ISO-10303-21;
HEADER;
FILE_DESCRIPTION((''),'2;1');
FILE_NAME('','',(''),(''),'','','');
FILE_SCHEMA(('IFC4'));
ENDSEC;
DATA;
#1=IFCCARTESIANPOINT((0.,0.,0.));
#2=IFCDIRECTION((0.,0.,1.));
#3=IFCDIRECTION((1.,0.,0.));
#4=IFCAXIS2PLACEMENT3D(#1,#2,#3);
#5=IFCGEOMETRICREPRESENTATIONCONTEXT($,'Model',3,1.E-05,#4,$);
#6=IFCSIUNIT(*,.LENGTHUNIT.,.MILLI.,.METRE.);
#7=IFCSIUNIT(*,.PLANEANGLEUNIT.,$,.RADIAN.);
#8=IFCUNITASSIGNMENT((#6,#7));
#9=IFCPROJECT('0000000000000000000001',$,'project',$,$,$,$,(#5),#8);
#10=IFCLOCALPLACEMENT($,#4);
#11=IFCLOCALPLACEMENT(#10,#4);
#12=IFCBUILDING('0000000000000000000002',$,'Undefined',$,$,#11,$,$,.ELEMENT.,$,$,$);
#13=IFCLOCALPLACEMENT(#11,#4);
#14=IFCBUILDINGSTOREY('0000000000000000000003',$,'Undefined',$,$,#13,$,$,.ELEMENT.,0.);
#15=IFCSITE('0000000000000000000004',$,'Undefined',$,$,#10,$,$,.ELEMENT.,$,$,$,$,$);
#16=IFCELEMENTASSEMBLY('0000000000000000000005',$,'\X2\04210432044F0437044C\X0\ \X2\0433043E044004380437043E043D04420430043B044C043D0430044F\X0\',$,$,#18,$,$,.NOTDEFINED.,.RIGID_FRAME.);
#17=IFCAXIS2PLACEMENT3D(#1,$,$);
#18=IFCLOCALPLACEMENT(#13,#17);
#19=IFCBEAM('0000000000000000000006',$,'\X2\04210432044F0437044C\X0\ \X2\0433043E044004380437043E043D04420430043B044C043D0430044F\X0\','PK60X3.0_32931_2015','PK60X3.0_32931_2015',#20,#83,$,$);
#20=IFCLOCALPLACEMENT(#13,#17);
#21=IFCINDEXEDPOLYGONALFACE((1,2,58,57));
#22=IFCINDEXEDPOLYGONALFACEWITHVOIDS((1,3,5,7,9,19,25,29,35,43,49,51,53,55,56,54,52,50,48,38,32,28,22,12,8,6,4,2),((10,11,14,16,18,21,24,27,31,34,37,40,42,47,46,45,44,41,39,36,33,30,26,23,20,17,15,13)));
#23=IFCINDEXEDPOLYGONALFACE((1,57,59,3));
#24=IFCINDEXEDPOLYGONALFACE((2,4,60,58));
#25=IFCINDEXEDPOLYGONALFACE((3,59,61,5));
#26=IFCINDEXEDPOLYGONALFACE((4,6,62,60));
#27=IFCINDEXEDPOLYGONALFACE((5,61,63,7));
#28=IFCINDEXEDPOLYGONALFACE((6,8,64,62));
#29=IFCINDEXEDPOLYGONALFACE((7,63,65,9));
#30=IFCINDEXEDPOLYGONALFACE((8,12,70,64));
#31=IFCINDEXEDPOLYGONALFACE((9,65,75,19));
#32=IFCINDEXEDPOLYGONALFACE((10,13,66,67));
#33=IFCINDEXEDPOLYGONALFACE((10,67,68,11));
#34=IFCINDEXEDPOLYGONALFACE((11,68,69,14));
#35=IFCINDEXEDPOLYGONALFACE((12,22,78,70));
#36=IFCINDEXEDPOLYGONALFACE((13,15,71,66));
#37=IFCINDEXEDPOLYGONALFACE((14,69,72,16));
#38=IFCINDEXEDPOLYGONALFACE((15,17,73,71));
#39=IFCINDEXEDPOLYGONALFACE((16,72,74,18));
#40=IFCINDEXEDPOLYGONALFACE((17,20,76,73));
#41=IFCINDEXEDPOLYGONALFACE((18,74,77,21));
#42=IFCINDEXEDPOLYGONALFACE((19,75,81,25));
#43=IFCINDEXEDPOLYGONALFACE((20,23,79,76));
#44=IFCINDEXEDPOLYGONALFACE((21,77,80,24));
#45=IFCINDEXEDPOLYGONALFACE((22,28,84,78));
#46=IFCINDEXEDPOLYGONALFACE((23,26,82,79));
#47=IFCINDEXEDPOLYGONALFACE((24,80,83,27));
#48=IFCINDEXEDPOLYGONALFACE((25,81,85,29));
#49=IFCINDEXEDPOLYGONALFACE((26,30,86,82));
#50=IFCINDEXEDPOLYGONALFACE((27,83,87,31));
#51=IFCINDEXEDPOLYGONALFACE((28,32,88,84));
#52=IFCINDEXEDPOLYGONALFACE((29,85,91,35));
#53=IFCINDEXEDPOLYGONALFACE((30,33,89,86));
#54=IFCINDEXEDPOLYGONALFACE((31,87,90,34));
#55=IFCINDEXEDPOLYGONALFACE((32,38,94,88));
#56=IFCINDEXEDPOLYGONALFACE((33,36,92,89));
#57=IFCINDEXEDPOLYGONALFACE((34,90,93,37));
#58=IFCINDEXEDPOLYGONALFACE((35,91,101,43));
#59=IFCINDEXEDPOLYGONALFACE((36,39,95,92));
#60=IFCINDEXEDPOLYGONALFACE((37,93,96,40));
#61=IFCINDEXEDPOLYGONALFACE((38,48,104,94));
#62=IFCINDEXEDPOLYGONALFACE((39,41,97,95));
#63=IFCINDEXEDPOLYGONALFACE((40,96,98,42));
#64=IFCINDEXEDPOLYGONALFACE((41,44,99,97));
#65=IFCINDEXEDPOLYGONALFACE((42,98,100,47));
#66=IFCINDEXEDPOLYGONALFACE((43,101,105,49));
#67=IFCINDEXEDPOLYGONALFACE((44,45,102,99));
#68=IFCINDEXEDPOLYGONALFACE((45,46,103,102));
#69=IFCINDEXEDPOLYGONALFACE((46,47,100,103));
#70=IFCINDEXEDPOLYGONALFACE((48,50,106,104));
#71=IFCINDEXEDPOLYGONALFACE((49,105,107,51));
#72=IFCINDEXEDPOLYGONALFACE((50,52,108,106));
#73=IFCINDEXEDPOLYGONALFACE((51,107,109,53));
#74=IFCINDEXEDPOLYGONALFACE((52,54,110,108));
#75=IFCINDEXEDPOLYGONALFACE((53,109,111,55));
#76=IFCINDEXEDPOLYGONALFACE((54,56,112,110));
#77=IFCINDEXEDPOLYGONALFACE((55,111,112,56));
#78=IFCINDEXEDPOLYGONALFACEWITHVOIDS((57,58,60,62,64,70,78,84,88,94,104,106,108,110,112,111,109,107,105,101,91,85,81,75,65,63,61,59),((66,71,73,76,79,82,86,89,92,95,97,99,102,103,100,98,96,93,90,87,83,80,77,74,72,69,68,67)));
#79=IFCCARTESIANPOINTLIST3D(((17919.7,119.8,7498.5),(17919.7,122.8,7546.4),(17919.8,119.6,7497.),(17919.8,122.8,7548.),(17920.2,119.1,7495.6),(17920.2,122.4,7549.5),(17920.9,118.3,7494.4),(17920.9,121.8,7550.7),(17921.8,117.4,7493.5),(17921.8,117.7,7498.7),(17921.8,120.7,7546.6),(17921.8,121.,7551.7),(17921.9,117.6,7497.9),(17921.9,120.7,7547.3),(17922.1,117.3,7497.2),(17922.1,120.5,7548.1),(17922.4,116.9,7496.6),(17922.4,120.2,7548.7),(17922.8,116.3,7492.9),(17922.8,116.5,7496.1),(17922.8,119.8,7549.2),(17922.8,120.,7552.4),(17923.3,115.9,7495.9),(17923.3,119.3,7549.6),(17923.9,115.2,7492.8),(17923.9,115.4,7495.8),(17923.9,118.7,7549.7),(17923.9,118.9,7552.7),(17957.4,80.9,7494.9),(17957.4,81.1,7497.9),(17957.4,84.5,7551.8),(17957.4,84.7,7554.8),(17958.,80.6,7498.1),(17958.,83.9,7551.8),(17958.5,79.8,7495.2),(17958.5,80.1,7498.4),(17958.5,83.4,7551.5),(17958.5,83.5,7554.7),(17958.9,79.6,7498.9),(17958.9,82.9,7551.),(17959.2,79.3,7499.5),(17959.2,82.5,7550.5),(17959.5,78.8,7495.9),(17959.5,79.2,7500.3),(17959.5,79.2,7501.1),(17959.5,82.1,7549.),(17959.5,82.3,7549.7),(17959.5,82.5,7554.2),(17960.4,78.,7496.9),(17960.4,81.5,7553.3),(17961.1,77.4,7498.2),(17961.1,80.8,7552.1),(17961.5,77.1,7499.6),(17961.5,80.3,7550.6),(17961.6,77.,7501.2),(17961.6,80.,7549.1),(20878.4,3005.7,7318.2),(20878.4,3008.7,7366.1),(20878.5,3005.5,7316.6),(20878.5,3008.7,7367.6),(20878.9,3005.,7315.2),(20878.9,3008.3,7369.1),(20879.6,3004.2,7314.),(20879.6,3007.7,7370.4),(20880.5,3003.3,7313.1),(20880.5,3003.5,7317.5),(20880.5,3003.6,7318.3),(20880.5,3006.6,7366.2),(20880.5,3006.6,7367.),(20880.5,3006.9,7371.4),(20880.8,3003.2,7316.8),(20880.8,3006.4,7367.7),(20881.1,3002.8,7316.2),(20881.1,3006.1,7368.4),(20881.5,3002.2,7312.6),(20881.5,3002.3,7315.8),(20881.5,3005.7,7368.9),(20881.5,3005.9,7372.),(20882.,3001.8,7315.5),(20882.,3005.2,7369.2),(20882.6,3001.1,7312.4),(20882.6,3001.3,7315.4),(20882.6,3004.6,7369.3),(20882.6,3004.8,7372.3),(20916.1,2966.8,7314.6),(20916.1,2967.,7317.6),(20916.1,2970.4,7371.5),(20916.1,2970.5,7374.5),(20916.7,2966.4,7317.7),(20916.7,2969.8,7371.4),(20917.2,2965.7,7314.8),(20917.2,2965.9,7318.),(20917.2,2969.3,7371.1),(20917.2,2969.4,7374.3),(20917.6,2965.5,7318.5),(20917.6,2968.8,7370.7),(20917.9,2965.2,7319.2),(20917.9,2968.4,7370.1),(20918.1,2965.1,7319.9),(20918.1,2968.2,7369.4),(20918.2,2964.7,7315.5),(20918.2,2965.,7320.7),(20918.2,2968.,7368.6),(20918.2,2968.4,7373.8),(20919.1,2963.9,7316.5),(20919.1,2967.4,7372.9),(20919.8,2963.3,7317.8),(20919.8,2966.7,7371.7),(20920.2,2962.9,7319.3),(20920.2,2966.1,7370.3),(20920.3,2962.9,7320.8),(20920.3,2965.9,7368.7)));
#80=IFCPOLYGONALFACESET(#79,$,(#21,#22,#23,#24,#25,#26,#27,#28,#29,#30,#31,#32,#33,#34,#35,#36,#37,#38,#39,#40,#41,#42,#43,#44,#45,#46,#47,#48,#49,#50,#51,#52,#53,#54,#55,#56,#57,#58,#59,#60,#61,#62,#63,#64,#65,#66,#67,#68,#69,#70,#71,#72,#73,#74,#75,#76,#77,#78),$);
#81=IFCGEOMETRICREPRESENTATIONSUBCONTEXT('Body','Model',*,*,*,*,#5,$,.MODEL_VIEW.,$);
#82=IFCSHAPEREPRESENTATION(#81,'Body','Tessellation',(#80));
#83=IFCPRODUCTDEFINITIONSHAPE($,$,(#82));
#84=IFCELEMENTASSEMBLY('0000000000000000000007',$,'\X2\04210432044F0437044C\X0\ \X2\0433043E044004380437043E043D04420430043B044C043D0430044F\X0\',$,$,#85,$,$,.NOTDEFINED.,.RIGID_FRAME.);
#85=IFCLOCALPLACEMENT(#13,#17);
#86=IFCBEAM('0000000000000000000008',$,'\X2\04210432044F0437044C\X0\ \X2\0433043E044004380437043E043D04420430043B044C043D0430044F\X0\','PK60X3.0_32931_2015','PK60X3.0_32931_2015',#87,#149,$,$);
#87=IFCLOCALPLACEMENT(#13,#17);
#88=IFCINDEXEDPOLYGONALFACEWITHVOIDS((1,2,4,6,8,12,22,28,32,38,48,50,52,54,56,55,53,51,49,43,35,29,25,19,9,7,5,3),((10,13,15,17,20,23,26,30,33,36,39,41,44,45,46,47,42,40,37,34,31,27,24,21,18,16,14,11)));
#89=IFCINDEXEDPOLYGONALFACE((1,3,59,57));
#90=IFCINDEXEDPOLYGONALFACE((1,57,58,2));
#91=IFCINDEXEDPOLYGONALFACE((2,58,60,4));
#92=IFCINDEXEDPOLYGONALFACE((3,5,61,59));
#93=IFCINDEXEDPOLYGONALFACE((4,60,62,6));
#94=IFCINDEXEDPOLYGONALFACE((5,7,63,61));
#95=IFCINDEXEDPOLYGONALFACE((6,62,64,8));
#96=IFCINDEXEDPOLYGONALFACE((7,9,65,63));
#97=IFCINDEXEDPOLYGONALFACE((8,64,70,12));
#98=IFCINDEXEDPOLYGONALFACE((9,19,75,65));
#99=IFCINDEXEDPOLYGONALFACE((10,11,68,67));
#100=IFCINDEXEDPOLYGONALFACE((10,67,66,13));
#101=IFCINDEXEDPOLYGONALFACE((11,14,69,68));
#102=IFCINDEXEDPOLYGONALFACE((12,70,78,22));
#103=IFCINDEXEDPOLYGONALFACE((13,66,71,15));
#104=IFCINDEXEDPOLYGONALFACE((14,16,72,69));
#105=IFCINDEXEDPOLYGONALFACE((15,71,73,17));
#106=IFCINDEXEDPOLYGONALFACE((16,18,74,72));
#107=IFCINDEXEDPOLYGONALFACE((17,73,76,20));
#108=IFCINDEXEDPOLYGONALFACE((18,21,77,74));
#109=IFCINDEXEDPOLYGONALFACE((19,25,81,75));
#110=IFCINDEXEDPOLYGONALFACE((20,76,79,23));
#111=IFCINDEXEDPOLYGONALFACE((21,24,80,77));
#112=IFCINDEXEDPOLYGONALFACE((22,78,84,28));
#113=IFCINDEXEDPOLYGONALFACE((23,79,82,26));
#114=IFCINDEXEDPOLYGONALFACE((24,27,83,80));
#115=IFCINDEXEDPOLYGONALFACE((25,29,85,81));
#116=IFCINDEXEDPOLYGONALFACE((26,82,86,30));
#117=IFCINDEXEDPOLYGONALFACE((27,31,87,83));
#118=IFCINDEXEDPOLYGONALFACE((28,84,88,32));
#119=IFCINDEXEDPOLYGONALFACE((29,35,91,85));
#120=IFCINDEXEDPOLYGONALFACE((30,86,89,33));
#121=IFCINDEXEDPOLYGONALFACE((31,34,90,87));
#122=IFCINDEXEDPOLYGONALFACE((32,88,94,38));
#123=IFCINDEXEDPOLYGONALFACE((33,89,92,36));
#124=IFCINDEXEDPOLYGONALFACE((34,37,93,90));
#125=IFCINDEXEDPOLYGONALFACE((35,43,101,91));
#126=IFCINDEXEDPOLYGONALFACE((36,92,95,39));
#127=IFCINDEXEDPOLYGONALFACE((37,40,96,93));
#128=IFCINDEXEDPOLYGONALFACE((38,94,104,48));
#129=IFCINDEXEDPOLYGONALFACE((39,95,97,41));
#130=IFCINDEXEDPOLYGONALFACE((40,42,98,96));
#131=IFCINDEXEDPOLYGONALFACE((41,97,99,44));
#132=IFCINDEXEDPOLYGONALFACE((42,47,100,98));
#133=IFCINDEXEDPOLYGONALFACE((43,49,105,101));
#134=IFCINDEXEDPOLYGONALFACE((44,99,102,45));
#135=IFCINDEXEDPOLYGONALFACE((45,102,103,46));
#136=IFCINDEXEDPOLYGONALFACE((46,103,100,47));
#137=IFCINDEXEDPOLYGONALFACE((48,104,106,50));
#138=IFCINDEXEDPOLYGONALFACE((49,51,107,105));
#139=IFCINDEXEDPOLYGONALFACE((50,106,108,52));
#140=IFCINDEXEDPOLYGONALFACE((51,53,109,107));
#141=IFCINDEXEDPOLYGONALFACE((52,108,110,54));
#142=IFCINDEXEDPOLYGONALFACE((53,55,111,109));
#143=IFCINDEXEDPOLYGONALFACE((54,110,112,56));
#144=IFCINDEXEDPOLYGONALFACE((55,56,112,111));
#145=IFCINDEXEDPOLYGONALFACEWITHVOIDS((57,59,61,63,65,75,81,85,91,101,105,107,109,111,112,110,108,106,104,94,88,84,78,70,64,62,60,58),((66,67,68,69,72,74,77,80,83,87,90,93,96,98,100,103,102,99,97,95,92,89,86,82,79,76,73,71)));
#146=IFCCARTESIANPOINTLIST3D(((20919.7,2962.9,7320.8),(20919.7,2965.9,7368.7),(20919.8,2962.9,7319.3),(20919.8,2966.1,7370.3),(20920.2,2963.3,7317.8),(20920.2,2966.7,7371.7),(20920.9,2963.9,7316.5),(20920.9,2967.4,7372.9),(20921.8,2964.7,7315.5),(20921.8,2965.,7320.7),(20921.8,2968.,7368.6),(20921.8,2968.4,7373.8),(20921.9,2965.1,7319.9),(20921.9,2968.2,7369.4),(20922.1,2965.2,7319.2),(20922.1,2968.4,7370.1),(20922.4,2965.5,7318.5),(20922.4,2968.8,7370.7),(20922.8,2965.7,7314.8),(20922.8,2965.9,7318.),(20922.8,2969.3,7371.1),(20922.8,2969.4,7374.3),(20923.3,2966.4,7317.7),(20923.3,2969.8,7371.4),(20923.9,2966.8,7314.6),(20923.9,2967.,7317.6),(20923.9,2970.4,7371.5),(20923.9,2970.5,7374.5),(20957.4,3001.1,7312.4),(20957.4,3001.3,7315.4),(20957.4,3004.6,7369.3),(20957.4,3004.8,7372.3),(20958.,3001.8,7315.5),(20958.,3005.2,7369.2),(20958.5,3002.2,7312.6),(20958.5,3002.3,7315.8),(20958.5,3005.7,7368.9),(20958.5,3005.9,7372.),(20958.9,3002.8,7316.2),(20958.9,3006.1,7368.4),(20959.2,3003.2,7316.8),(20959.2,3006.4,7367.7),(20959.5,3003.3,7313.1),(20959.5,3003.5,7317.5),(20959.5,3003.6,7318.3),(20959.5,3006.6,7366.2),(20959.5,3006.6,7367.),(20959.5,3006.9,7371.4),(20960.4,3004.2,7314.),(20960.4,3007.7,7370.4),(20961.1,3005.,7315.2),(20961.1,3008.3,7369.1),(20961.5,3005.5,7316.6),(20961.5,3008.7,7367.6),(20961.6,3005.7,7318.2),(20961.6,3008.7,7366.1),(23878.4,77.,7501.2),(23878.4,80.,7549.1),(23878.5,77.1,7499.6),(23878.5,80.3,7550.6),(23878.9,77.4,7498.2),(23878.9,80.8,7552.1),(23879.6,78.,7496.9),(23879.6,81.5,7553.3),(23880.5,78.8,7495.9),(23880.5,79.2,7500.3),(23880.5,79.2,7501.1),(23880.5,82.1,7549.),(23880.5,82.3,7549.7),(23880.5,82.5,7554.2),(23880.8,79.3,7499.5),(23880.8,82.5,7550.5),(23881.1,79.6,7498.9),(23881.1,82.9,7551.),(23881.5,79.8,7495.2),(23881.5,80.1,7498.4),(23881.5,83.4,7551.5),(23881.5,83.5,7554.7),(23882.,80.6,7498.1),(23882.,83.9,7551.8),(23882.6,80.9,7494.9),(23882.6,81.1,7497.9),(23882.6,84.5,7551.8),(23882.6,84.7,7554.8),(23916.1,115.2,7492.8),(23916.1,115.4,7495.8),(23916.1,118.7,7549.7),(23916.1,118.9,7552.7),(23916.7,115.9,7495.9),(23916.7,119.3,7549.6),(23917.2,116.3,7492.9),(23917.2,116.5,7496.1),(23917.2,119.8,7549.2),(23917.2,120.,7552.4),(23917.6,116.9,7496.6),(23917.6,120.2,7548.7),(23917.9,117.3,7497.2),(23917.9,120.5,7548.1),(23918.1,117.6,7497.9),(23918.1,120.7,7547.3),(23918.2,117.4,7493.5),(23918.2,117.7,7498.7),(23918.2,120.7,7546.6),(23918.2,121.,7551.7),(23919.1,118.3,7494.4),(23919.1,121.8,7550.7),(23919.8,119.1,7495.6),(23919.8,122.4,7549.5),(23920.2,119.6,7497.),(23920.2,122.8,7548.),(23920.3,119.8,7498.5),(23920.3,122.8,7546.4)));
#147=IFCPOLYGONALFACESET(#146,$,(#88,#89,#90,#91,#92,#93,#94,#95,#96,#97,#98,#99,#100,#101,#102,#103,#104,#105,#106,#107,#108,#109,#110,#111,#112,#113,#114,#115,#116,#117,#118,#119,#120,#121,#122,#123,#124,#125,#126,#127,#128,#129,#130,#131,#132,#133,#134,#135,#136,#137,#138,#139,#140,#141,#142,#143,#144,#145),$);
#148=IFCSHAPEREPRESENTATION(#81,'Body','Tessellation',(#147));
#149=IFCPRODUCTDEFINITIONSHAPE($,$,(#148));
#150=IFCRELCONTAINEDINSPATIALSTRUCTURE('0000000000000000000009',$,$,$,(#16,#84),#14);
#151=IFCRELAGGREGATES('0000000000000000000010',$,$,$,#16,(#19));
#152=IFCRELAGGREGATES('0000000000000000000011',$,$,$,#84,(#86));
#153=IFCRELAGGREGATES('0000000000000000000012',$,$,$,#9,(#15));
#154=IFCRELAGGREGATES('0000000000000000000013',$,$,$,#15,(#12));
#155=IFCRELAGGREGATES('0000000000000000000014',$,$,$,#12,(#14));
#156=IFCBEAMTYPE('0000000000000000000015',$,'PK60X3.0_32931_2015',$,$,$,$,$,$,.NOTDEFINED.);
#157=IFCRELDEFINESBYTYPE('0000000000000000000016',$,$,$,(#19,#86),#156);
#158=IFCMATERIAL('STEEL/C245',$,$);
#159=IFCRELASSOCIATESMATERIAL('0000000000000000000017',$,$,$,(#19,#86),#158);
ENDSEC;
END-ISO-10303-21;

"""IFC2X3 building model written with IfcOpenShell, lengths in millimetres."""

from ifc_helpers import new_model, si_unit, frame, origin_with_axes, origin_2d_with_axis, place, context, subcontext, project, spatial, hollow_rectangle, extrude, material, type_object, element, aggregate, save


model = new_model("IFC2X3")

# Units and contexts
model_context = context("Model", 3, precision=1e-05, world=origin_with_axes())
body_context = subcontext(model_context, "Body", "Model", "MODEL_VIEW")
ifc_project = project(units=[si_unit("LENGTHUNIT", "METRE", prefix="MILLI"), si_unit("PLANEANGLEUNIT", "RADIAN")], contexts=[model_context])

# Site, building, storey
site_placement = place(None, origin_with_axes())
site = spatial("IfcSite", under=ifc_project, at=site_placement, Name="Undefined", CompositionType="ELEMENT")
building_placement = place(site_placement, origin_with_axes())
building = spatial("IfcBuilding", under=site, at=building_placement, Name="Undefined", CompositionType="ELEMENT")
storey_placement = place(building_placement, origin_with_axes())
storey = spatial("IfcBuildingStorey", under=building, at=storey_placement, Name="Undefined", CompositionType="ELEMENT", Elevation=0.0)

# Shared definitions
ifc_material = material(Name="STEEL/C245")

# Element assemblies, beams
beam_type_1 = type_object("IfcBeamType", Name="PK60X3.0_32931_2015", PredefinedType="NOTDEFINED")
assembly_1_placement = place(storey_placement, origin_with_axes())
assembly_1 = element("IfcElementAssembly", 1, at=assembly_1_placement, inside=storey, Name="Связь горизонтальная", AssemblyPlace="NOTDEFINED", PredefinedType="RIGID_FRAME")
beam_1_placement = place(assembly_1_placement, frame((17940.7, 99.9, 7523.8), z_axis=(0.0, 0.062378, 0.998053), x_axis=(0.715179, 0.69758, -0.043599)))
beam_1 = element("IfcBeam", 2, at=beam_1_placement, type_object=beam_type_1, material=ifc_material, Name="Связь горизонтальная", Description="PK60X3.0_32931_2015", ObjectType="PK60X3.0_32931_2015", context=body_context, shape_type="SweptSolid", body=[
    extrude(hollow_rectangle(XDim=60.0, YDim=60.0, WallThickness=3.0, InnerFilletRadius=3.0, OuterFilletRadius=6.0, at=origin_2d_with_axis()), frame((4137.0, 0.0, 0.0), z_axis=(-1.0, 0.0, 0.0), x_axis=(0.0, -1.0, 0.0)), (0.0, 0.0, 1.0), 4137.0),
])
aggregate(assembly_1, [beam_1])
assembly_2_placement = place(storey_placement, origin_with_axes())
assembly_2 = element("IfcElementAssembly", 3, at=assembly_2_placement, inside=storey, Name="Связь горизонтальная", AssemblyPlace="NOTDEFINED", PredefinedType="RIGID_FRAME")
beam_2_placement = place(assembly_2_placement, frame((23899.3, 99.9, 7523.8), z_axis=(0.0, 0.062378, 0.998053), x_axis=(-0.715179, 0.69758, -0.043599)))
beam_2 = element("IfcBeam", 4, at=beam_2_placement, type_object=beam_type_1, material=ifc_material, Name="Связь горизонтальная", Description="PK60X3.0_32931_2015", ObjectType="PK60X3.0_32931_2015", context=body_context, shape_type="SweptSolid", body=[
    extrude(hollow_rectangle(XDim=60.0, YDim=60.0, WallThickness=3.0, InnerFilletRadius=3.0, OuterFilletRadius=6.0, at=origin_2d_with_axis()), frame((4137.0, 0.0, 0.0), z_axis=(-1.0, 0.0, 0.0), x_axis=(0.0, -1.0, 0.0)), (0.0, 0.0, 1.0), 4137.0),
])
aggregate(assembly_2, [beam_2])

save(model, "model.ifc")
